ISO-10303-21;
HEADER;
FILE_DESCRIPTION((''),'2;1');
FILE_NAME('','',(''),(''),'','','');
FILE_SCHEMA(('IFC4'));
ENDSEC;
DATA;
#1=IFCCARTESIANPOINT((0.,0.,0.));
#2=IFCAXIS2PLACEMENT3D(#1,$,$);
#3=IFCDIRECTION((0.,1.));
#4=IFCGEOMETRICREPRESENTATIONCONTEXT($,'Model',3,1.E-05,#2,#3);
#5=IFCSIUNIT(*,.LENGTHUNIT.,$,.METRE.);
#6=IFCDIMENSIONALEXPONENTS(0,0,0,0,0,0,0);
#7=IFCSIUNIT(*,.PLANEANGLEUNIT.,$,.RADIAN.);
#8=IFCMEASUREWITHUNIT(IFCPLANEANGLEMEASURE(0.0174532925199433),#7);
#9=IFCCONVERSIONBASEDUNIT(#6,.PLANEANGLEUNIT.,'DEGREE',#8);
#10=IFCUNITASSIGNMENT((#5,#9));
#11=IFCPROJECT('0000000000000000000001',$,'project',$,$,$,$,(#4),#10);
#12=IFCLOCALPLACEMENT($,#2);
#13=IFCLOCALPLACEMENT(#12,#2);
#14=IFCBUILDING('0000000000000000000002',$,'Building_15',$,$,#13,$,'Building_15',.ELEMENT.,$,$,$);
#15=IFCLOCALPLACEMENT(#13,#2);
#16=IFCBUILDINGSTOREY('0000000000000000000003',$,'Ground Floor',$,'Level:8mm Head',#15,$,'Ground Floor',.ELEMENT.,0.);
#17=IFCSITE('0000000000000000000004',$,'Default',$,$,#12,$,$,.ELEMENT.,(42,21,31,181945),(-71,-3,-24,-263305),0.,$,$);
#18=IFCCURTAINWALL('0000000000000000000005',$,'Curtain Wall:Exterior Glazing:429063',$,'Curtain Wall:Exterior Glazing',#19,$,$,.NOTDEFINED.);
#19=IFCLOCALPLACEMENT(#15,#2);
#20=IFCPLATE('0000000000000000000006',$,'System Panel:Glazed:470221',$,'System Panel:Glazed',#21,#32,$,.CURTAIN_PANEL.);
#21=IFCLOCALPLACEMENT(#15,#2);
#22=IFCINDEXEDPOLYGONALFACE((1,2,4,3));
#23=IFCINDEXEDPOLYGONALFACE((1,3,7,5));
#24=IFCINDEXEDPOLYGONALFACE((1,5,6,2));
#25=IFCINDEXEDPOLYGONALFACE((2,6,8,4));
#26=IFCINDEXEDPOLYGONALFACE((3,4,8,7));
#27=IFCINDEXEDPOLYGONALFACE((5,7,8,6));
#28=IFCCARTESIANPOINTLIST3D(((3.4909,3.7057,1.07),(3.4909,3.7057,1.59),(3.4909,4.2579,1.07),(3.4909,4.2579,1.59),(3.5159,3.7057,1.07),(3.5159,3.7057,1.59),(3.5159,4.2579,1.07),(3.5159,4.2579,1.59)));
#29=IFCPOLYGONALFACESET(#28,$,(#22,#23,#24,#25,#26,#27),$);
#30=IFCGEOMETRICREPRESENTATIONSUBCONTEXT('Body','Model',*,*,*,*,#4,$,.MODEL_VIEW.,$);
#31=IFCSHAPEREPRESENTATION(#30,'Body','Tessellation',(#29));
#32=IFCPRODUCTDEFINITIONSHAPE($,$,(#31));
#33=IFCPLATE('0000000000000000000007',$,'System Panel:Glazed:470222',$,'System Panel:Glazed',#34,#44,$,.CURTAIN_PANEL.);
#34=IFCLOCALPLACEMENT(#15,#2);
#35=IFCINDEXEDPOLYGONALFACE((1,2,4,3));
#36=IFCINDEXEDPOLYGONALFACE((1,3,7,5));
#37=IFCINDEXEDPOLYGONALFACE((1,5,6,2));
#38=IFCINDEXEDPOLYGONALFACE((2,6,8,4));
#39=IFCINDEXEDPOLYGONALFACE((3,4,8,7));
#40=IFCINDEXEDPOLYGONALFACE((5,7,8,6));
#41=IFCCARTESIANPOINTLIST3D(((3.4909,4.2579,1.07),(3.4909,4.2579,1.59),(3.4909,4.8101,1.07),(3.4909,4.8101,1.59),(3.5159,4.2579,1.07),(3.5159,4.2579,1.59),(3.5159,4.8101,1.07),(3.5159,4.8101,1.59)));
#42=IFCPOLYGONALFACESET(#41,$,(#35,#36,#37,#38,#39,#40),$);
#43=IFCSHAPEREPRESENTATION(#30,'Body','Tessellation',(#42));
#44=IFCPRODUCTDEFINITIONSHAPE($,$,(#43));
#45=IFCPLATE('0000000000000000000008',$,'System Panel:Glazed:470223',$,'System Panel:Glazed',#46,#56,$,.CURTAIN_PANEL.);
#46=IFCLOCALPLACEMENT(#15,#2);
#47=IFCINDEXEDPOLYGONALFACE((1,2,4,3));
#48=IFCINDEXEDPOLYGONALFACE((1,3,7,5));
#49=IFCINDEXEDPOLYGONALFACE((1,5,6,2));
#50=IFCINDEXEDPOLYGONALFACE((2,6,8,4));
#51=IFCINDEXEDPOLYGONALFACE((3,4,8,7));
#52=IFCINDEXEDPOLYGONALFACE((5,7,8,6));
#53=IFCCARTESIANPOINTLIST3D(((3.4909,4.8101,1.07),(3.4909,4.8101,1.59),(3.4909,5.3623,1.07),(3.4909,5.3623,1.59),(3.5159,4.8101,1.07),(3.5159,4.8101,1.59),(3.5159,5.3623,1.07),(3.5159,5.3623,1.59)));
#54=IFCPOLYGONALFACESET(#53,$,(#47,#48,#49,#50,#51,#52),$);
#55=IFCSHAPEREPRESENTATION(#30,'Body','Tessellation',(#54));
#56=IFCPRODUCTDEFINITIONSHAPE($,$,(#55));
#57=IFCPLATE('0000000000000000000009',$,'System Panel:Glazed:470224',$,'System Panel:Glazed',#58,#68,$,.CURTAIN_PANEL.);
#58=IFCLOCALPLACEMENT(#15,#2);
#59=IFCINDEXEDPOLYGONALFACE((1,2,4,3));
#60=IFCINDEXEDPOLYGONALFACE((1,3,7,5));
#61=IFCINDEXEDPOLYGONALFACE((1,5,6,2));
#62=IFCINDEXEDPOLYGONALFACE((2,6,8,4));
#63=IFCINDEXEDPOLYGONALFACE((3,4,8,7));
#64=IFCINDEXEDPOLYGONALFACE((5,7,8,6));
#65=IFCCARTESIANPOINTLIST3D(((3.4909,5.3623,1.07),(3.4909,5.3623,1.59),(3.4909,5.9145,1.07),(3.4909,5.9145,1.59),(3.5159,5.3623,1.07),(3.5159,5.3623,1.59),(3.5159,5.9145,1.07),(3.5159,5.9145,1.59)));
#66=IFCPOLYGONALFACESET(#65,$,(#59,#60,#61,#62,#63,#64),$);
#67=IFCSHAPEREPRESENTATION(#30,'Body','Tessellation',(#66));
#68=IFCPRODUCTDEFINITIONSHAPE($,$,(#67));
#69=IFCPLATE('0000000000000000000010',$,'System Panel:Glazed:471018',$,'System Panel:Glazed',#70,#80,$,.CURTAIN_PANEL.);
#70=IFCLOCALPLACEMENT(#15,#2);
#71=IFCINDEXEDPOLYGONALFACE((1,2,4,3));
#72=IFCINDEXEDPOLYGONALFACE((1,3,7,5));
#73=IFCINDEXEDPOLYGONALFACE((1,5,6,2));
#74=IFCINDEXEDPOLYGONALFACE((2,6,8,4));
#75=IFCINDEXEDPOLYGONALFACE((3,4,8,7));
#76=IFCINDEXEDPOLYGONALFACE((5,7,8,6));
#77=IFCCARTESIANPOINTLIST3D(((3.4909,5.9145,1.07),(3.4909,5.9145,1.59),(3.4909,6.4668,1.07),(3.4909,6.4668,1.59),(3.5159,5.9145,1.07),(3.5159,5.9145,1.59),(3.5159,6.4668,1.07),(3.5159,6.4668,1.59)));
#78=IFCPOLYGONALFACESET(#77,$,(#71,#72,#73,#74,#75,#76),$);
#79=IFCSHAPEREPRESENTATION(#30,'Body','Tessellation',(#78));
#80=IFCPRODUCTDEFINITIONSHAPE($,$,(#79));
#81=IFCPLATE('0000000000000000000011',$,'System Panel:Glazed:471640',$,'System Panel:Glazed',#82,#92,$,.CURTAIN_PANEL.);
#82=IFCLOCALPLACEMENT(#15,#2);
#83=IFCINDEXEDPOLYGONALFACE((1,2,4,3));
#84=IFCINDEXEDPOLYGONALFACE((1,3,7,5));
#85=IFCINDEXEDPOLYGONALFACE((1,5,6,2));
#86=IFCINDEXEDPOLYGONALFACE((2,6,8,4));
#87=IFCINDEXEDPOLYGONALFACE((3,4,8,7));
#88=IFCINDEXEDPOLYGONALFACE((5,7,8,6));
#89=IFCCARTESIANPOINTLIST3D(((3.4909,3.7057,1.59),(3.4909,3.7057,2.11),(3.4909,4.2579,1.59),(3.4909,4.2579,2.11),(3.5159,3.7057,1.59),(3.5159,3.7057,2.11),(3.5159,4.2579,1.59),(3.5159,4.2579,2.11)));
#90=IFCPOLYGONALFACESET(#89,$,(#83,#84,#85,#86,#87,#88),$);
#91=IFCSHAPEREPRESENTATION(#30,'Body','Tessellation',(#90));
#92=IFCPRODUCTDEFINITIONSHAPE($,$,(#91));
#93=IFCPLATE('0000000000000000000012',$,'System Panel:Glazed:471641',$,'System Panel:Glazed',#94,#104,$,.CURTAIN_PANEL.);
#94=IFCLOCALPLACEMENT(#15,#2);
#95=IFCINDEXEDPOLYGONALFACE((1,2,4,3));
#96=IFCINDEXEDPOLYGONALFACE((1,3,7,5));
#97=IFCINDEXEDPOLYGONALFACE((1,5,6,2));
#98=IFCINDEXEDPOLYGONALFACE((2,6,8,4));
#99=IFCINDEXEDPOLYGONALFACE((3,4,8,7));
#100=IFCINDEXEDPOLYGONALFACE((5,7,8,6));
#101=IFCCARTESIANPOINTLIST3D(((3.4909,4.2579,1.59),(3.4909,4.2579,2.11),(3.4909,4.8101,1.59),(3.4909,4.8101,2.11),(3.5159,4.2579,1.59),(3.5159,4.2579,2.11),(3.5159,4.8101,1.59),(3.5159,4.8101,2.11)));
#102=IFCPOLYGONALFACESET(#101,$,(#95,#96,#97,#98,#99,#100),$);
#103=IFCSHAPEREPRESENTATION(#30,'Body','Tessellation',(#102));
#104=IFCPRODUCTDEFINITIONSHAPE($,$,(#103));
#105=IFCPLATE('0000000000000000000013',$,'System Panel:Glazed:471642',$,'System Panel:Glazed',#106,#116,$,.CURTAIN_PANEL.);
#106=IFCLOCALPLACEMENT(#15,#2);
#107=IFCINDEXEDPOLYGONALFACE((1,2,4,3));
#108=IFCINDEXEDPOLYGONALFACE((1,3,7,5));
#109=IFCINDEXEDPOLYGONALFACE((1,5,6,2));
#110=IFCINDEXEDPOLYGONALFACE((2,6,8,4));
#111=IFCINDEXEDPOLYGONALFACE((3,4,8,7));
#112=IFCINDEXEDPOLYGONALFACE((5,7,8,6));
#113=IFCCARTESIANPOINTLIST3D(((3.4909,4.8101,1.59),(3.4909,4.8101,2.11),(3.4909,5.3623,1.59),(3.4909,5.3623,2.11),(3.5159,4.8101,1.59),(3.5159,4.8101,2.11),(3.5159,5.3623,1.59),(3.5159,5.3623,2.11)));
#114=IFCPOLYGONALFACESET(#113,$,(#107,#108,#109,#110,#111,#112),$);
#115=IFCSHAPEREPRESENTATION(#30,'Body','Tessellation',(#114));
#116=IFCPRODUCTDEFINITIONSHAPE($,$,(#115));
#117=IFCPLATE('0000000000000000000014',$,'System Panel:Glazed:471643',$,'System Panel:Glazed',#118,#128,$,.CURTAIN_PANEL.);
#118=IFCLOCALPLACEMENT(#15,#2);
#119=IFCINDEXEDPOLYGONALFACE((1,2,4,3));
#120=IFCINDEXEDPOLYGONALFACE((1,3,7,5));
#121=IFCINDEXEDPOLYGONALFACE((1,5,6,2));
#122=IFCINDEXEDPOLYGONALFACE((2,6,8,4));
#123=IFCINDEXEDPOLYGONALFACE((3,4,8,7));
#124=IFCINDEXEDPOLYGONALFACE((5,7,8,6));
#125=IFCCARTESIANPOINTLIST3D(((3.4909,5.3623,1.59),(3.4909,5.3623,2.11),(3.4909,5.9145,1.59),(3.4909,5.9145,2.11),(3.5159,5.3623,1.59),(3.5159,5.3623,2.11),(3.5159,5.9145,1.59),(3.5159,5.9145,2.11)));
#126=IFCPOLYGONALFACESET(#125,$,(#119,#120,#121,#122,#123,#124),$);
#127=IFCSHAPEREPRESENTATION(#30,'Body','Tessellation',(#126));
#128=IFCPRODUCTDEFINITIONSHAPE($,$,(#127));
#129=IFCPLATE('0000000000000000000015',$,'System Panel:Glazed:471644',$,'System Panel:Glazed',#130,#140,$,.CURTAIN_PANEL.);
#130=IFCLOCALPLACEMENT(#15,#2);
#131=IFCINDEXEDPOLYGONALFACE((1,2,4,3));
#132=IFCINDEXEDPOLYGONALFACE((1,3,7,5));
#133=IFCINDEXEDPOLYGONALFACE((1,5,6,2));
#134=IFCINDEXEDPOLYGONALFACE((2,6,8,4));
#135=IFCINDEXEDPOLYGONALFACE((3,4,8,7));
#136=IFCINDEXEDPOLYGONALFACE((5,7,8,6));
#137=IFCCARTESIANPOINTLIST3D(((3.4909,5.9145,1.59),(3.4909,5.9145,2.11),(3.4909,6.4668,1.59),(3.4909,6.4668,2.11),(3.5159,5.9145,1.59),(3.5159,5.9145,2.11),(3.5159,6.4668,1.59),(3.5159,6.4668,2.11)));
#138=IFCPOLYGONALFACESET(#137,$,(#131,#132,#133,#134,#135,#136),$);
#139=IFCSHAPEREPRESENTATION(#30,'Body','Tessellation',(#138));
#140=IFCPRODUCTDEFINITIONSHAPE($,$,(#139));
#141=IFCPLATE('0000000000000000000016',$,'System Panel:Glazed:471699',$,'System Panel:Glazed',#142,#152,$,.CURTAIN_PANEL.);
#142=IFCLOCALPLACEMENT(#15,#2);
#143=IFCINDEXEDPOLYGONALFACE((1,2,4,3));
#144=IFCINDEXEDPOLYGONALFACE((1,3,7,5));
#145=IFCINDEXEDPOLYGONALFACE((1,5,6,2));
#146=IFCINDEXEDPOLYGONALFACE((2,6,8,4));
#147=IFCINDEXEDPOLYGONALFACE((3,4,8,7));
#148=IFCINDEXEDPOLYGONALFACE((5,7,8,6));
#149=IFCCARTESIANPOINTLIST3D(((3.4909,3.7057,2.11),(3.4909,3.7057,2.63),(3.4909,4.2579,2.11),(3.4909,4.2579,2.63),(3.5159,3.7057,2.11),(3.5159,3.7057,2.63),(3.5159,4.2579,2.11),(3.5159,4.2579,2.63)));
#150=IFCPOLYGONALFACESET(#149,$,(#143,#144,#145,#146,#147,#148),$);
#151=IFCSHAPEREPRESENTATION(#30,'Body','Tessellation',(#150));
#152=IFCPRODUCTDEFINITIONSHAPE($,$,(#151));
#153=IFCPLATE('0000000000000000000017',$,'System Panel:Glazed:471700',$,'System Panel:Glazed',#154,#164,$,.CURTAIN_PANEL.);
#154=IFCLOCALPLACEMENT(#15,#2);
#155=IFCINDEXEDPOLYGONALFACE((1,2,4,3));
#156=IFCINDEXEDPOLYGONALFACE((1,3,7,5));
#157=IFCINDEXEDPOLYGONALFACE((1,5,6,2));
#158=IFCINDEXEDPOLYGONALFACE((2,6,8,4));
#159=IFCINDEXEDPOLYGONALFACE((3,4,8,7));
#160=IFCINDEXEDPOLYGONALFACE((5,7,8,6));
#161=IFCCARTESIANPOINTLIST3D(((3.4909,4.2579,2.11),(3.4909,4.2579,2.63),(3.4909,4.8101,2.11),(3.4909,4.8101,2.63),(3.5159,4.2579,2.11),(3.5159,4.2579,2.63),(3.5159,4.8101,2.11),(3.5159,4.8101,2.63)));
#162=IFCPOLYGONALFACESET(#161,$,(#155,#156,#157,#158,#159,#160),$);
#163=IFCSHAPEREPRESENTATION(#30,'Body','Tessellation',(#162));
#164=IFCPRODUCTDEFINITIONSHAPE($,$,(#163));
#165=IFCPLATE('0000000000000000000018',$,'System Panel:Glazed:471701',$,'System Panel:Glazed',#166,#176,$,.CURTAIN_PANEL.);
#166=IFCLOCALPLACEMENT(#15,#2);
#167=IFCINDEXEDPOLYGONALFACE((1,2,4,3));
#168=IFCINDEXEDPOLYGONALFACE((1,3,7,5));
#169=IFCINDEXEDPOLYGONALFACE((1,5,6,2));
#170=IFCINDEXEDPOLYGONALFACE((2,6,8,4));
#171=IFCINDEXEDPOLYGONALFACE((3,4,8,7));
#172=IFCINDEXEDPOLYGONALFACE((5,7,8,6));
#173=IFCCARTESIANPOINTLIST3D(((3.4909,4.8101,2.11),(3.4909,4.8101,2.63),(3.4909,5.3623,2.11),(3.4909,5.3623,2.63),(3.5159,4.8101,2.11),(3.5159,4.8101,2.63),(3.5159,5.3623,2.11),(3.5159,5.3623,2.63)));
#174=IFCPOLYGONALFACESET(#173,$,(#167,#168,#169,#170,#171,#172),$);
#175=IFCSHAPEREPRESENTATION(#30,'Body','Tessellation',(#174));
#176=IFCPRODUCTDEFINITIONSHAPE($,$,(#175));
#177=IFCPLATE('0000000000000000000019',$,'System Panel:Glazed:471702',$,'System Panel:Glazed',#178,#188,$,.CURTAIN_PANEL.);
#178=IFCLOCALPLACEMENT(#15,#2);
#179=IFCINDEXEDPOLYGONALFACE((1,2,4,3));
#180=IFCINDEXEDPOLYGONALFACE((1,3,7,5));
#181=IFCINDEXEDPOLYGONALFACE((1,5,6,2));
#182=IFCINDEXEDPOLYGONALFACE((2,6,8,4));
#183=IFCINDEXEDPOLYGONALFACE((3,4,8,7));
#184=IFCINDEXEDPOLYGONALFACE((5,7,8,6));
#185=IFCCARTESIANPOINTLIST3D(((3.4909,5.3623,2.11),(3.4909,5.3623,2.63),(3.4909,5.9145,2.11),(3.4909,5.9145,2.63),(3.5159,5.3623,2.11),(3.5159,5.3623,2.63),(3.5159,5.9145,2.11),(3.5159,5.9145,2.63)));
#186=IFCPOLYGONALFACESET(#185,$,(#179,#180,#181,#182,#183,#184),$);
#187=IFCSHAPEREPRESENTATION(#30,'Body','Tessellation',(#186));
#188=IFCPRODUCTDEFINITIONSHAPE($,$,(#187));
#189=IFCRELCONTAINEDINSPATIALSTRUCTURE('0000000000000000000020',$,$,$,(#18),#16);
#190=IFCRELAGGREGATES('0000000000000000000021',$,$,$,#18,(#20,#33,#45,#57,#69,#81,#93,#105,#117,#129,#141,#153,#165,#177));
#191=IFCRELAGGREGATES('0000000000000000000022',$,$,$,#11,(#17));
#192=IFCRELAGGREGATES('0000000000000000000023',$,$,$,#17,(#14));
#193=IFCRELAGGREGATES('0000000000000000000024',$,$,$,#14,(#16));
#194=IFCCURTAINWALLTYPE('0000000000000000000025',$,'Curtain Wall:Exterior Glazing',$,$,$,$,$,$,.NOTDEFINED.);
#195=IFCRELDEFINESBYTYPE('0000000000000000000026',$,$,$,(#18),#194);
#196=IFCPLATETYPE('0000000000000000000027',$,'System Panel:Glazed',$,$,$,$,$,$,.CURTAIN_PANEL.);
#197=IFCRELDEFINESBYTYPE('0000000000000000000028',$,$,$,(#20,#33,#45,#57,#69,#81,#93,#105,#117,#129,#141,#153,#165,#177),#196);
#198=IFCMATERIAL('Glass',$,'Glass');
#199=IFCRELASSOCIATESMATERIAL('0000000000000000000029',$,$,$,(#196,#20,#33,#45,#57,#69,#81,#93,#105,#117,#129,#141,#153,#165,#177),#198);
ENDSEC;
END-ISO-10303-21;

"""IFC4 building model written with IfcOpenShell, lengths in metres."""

from ifc_helpers import new_model, entity, si_unit, converted_unit, direction, frame, origin, place, context, subcontext, project, spatial, indexed_curve, outline, extrude, source, transform, mapped, material, type_object, type_shapes, element, aggregate, save


model = new_model("IFC4")

# Units and contexts
model_context = context("Model", 3, precision=1e-05, world=origin(), true_north=direction((0.0, 1.0)))
body_context = subcontext(model_context, "Body", "Model", "MODEL_VIEW")
ifc_project = project(units=[si_unit("LENGTHUNIT", "METRE"), converted_unit("PLANEANGLEUNIT", "DEGREE", entity("IfcPlaneAngleMeasure", 0.0174532925199433), si_unit("PLANEANGLEUNIT", "RADIAN"), dimensions=[0, 0, 0, 0, 0, 0, 0])], contexts=[model_context])

# Site, building, storey
site_placement = place(None, origin())
site = spatial("IfcSite", under=ifc_project, at=site_placement, Name="Default", CompositionType="ELEMENT", RefLatitude=(42, 21, 31, 181945), RefLongitude=(-71, -3, -24, -263305), RefElevation=0.0)
building_placement = place(site_placement, origin())
building = spatial("IfcBuilding", under=site, at=building_placement, Name="Building_15", LongName="Building_15", CompositionType="ELEMENT")
storey_placement = place(building_placement, origin())
storey = spatial("IfcBuildingStorey", under=building, at=storey_placement, Name="Ground Floor", ObjectType="Level:8mm Head", LongName="Ground Floor", CompositionType="ELEMENT", Elevation=0.0)

# Curtain wall, plates
curtain_wall_type = type_object("IfcCurtainWallType", Name="Curtain Wall:Exterior Glazing", PredefinedType="NOTDEFINED")
curtain_wall_placement = place(storey_placement, origin())
curtain_wall = element("IfcCurtainWall", 1, at=curtain_wall_placement, inside=storey, type_object=curtain_wall_type, Name="Curtain Wall:Exterior Glazing:429063", ObjectType="Curtain Wall:Exterior Glazing", PredefinedType="NOTDEFINED")
ifc_material_1 = material(Name="Glass", Category="Glass")
plate_type_1 = type_object("IfcPlateType", Name="System Panel:Glazed", PredefinedType="CURTAIN_PANEL", material=ifc_material_1)
shared_shape_1 = source(origin(), body_context, "Body", "SweptSolid", [
    extrude(outline(indexed_curve([(-0.0125, -0.2761), (0.0125, -0.2761), (0.0125, 0.2761), (-0.0125, 0.2761), (-0.0125, -0.2761)], self_intersect=False)), frame((0.0, 0.037, 0.0), z_axis=(0.0, 0.0, 1.0), x_axis=(0.0, 1.0, 0.0)), (0.0, 0.0, 1.0), 0.52),
])
type_shapes(plate_type_1, [shared_shape_1])
plate_1_placement = place(curtain_wall_placement, frame((3.5404, 3.9818, 1.07), z_axis=(0.0, 0.0, 1.0), x_axis=(0.0, 1.0, 0.0)))
plate_1 = element("IfcPlate", 2, at=plate_1_placement, type_object=plate_type_1, material=ifc_material_1, Name="System Panel:Glazed:470221", ObjectType="System Panel:Glazed", PredefinedType="CURTAIN_PANEL", context=body_context, shape_type="MappedRepresentation", body=[
    mapped(shared_shape_1, transform((0.0, 0.0, 0.0), scale=1.0)),
])
plate_2_placement = place(curtain_wall_placement, frame((3.5404, 4.534, 1.07), z_axis=(0.0, 0.0, 1.0), x_axis=(0.0, 1.0, 0.0)))
plate_2 = element("IfcPlate", 3, at=plate_2_placement, type_object=plate_type_1, material=ifc_material_1, Name="System Panel:Glazed:470222", ObjectType="System Panel:Glazed", PredefinedType="CURTAIN_PANEL", context=body_context, shape_type="MappedRepresentation", body=[
    mapped(shared_shape_1, transform((0.0, 0.0, 0.0), scale=1.0)),
])
plate_3_placement = place(curtain_wall_placement, frame((3.5404, 5.0862, 1.07), z_axis=(0.0, 0.0, 1.0), x_axis=(0.0, 1.0, 0.0)))
plate_3 = element("IfcPlate", 4, at=plate_3_placement, type_object=plate_type_1, material=ifc_material_1, Name="System Panel:Glazed:470223", ObjectType="System Panel:Glazed", PredefinedType="CURTAIN_PANEL", context=body_context, shape_type="MappedRepresentation", body=[
    mapped(shared_shape_1, transform((0.0, 0.0, 0.0), scale=1.0)),
])
plate_4_placement = place(curtain_wall_placement, frame((3.5404, 5.6384, 1.07), z_axis=(0.0, 0.0, 1.0), x_axis=(0.0, 1.0, 0.0)))
plate_4 = element("IfcPlate", 5, at=plate_4_placement, type_object=plate_type_1, material=ifc_material_1, Name="System Panel:Glazed:470224", ObjectType="System Panel:Glazed", PredefinedType="CURTAIN_PANEL", context=body_context, shape_type="MappedRepresentation", body=[
    mapped(shared_shape_1, transform((0.0, 0.0, 0.0), scale=1.0)),
])
plate_5_placement = place(curtain_wall_placement, frame((3.5404, 6.1907, 1.07), z_axis=(0.0, 0.0, 1.0), x_axis=(0.0, 1.0, 0.0)))
plate_5 = element("IfcPlate", 6, at=plate_5_placement, type_object=plate_type_1, material=ifc_material_1, Name="System Panel:Glazed:471018", ObjectType="System Panel:Glazed", PredefinedType="CURTAIN_PANEL", context=body_context, shape_type="MappedRepresentation", body=[
    mapped(shared_shape_1, transform((0.0, 0.0, 0.0), scale=1.0)),
])
plate_6_placement = place(curtain_wall_placement, frame((3.5404, 3.9818, 1.59), z_axis=(0.0, 0.0, 1.0), x_axis=(0.0, 1.0, 0.0)))
plate_6 = element("IfcPlate", 7, at=plate_6_placement, type_object=plate_type_1, material=ifc_material_1, Name="System Panel:Glazed:471640", ObjectType="System Panel:Glazed", PredefinedType="CURTAIN_PANEL", context=body_context, shape_type="MappedRepresentation", body=[
    mapped(shared_shape_1, transform((0.0, 0.0, 0.0), scale=1.0)),
])
plate_7_placement = place(curtain_wall_placement, frame((3.5404, 4.534, 1.59), z_axis=(0.0, 0.0, 1.0), x_axis=(0.0, 1.0, 0.0)))
plate_7 = element("IfcPlate", 8, at=plate_7_placement, type_object=plate_type_1, material=ifc_material_1, Name="System Panel:Glazed:471641", ObjectType="System Panel:Glazed", PredefinedType="CURTAIN_PANEL", context=body_context, shape_type="MappedRepresentation", body=[
    mapped(shared_shape_1, transform((0.0, 0.0, 0.0), scale=1.0)),
])
plate_8_placement = place(curtain_wall_placement, frame((3.5404, 5.0862, 1.59), z_axis=(0.0, 0.0, 1.0), x_axis=(0.0, 1.0, 0.0)))
plate_8 = element("IfcPlate", 9, at=plate_8_placement, type_object=plate_type_1, material=ifc_material_1, Name="System Panel:Glazed:471642", ObjectType="System Panel:Glazed", PredefinedType="CURTAIN_PANEL", context=body_context, shape_type="MappedRepresentation", body=[
    mapped(shared_shape_1, transform((0.0, 0.0, 0.0), scale=1.0)),
])
plate_9_placement = place(curtain_wall_placement, frame((3.5404, 5.6384, 1.59), z_axis=(0.0, 0.0, 1.0), x_axis=(0.0, 1.0, 0.0)))
plate_9 = element("IfcPlate", 10, at=plate_9_placement, type_object=plate_type_1, material=ifc_material_1, Name="System Panel:Glazed:471643", ObjectType="System Panel:Glazed", PredefinedType="CURTAIN_PANEL", context=body_context, shape_type="MappedRepresentation", body=[
    mapped(shared_shape_1, transform((0.0, 0.0, 0.0), scale=1.0)),
])
plate_10_placement = place(curtain_wall_placement, frame((3.5404, 6.1907, 1.59), z_axis=(0.0, 0.0, 1.0), x_axis=(0.0, 1.0, 0.0)))
plate_10 = element("IfcPlate", 11, at=plate_10_placement, type_object=plate_type_1, material=ifc_material_1, Name="System Panel:Glazed:471644", ObjectType="System Panel:Glazed", PredefinedType="CURTAIN_PANEL", context=body_context, shape_type="MappedRepresentation", body=[
    mapped(shared_shape_1, transform((0.0, 0.0, 0.0), scale=1.0)),
])
plate_11_placement = place(curtain_wall_placement, frame((3.5404, 3.9818, 2.11), z_axis=(0.0, 0.0, 1.0), x_axis=(0.0, 1.0, 0.0)))
plate_11 = element("IfcPlate", 12, at=plate_11_placement, type_object=plate_type_1, material=ifc_material_1, Name="System Panel:Glazed:471699", ObjectType="System Panel:Glazed", PredefinedType="CURTAIN_PANEL", context=body_context, shape_type="MappedRepresentation", body=[
    mapped(shared_shape_1, transform((0.0, 0.0, 0.0), scale=1.0)),
])
plate_12_placement = place(curtain_wall_placement, frame((3.5404, 4.534, 2.11), z_axis=(0.0, 0.0, 1.0), x_axis=(0.0, 1.0, 0.0)))
plate_12 = element("IfcPlate", 13, at=plate_12_placement, type_object=plate_type_1, material=ifc_material_1, Name="System Panel:Glazed:471700", ObjectType="System Panel:Glazed", PredefinedType="CURTAIN_PANEL", context=body_context, shape_type="MappedRepresentation", body=[
    mapped(shared_shape_1, transform((0.0, 0.0, 0.0), scale=1.0)),
])
plate_13_placement = place(curtain_wall_placement, frame((3.5404, 5.0862, 2.11), z_axis=(0.0, 0.0, 1.0), x_axis=(0.0, 1.0, 0.0)))
plate_13 = element("IfcPlate", 14, at=plate_13_placement, type_object=plate_type_1, material=ifc_material_1, Name="System Panel:Glazed:471701", ObjectType="System Panel:Glazed", PredefinedType="CURTAIN_PANEL", context=body_context, shape_type="MappedRepresentation", body=[
    mapped(shared_shape_1, transform((0.0, 0.0, 0.0), scale=1.0)),
])
plate_14_placement = place(curtain_wall_placement, frame((3.5404, 5.6384, 2.11), z_axis=(0.0, 0.0, 1.0), x_axis=(0.0, 1.0, 0.0)))
plate_14 = element("IfcPlate", 15, at=plate_14_placement, type_object=plate_type_1, material=ifc_material_1, Name="System Panel:Glazed:471702", ObjectType="System Panel:Glazed", PredefinedType="CURTAIN_PANEL", context=body_context, shape_type="MappedRepresentation", body=[
    mapped(shared_shape_1, transform((0.0, 0.0, 0.0), scale=1.0)),
])
aggregate(curtain_wall, [plate_1, plate_2, plate_3, plate_4, plate_5, plate_6, plate_7, plate_8, plate_9, plate_10, plate_11, plate_12, plate_13, plate_14])

save(model, "model.ifc")
